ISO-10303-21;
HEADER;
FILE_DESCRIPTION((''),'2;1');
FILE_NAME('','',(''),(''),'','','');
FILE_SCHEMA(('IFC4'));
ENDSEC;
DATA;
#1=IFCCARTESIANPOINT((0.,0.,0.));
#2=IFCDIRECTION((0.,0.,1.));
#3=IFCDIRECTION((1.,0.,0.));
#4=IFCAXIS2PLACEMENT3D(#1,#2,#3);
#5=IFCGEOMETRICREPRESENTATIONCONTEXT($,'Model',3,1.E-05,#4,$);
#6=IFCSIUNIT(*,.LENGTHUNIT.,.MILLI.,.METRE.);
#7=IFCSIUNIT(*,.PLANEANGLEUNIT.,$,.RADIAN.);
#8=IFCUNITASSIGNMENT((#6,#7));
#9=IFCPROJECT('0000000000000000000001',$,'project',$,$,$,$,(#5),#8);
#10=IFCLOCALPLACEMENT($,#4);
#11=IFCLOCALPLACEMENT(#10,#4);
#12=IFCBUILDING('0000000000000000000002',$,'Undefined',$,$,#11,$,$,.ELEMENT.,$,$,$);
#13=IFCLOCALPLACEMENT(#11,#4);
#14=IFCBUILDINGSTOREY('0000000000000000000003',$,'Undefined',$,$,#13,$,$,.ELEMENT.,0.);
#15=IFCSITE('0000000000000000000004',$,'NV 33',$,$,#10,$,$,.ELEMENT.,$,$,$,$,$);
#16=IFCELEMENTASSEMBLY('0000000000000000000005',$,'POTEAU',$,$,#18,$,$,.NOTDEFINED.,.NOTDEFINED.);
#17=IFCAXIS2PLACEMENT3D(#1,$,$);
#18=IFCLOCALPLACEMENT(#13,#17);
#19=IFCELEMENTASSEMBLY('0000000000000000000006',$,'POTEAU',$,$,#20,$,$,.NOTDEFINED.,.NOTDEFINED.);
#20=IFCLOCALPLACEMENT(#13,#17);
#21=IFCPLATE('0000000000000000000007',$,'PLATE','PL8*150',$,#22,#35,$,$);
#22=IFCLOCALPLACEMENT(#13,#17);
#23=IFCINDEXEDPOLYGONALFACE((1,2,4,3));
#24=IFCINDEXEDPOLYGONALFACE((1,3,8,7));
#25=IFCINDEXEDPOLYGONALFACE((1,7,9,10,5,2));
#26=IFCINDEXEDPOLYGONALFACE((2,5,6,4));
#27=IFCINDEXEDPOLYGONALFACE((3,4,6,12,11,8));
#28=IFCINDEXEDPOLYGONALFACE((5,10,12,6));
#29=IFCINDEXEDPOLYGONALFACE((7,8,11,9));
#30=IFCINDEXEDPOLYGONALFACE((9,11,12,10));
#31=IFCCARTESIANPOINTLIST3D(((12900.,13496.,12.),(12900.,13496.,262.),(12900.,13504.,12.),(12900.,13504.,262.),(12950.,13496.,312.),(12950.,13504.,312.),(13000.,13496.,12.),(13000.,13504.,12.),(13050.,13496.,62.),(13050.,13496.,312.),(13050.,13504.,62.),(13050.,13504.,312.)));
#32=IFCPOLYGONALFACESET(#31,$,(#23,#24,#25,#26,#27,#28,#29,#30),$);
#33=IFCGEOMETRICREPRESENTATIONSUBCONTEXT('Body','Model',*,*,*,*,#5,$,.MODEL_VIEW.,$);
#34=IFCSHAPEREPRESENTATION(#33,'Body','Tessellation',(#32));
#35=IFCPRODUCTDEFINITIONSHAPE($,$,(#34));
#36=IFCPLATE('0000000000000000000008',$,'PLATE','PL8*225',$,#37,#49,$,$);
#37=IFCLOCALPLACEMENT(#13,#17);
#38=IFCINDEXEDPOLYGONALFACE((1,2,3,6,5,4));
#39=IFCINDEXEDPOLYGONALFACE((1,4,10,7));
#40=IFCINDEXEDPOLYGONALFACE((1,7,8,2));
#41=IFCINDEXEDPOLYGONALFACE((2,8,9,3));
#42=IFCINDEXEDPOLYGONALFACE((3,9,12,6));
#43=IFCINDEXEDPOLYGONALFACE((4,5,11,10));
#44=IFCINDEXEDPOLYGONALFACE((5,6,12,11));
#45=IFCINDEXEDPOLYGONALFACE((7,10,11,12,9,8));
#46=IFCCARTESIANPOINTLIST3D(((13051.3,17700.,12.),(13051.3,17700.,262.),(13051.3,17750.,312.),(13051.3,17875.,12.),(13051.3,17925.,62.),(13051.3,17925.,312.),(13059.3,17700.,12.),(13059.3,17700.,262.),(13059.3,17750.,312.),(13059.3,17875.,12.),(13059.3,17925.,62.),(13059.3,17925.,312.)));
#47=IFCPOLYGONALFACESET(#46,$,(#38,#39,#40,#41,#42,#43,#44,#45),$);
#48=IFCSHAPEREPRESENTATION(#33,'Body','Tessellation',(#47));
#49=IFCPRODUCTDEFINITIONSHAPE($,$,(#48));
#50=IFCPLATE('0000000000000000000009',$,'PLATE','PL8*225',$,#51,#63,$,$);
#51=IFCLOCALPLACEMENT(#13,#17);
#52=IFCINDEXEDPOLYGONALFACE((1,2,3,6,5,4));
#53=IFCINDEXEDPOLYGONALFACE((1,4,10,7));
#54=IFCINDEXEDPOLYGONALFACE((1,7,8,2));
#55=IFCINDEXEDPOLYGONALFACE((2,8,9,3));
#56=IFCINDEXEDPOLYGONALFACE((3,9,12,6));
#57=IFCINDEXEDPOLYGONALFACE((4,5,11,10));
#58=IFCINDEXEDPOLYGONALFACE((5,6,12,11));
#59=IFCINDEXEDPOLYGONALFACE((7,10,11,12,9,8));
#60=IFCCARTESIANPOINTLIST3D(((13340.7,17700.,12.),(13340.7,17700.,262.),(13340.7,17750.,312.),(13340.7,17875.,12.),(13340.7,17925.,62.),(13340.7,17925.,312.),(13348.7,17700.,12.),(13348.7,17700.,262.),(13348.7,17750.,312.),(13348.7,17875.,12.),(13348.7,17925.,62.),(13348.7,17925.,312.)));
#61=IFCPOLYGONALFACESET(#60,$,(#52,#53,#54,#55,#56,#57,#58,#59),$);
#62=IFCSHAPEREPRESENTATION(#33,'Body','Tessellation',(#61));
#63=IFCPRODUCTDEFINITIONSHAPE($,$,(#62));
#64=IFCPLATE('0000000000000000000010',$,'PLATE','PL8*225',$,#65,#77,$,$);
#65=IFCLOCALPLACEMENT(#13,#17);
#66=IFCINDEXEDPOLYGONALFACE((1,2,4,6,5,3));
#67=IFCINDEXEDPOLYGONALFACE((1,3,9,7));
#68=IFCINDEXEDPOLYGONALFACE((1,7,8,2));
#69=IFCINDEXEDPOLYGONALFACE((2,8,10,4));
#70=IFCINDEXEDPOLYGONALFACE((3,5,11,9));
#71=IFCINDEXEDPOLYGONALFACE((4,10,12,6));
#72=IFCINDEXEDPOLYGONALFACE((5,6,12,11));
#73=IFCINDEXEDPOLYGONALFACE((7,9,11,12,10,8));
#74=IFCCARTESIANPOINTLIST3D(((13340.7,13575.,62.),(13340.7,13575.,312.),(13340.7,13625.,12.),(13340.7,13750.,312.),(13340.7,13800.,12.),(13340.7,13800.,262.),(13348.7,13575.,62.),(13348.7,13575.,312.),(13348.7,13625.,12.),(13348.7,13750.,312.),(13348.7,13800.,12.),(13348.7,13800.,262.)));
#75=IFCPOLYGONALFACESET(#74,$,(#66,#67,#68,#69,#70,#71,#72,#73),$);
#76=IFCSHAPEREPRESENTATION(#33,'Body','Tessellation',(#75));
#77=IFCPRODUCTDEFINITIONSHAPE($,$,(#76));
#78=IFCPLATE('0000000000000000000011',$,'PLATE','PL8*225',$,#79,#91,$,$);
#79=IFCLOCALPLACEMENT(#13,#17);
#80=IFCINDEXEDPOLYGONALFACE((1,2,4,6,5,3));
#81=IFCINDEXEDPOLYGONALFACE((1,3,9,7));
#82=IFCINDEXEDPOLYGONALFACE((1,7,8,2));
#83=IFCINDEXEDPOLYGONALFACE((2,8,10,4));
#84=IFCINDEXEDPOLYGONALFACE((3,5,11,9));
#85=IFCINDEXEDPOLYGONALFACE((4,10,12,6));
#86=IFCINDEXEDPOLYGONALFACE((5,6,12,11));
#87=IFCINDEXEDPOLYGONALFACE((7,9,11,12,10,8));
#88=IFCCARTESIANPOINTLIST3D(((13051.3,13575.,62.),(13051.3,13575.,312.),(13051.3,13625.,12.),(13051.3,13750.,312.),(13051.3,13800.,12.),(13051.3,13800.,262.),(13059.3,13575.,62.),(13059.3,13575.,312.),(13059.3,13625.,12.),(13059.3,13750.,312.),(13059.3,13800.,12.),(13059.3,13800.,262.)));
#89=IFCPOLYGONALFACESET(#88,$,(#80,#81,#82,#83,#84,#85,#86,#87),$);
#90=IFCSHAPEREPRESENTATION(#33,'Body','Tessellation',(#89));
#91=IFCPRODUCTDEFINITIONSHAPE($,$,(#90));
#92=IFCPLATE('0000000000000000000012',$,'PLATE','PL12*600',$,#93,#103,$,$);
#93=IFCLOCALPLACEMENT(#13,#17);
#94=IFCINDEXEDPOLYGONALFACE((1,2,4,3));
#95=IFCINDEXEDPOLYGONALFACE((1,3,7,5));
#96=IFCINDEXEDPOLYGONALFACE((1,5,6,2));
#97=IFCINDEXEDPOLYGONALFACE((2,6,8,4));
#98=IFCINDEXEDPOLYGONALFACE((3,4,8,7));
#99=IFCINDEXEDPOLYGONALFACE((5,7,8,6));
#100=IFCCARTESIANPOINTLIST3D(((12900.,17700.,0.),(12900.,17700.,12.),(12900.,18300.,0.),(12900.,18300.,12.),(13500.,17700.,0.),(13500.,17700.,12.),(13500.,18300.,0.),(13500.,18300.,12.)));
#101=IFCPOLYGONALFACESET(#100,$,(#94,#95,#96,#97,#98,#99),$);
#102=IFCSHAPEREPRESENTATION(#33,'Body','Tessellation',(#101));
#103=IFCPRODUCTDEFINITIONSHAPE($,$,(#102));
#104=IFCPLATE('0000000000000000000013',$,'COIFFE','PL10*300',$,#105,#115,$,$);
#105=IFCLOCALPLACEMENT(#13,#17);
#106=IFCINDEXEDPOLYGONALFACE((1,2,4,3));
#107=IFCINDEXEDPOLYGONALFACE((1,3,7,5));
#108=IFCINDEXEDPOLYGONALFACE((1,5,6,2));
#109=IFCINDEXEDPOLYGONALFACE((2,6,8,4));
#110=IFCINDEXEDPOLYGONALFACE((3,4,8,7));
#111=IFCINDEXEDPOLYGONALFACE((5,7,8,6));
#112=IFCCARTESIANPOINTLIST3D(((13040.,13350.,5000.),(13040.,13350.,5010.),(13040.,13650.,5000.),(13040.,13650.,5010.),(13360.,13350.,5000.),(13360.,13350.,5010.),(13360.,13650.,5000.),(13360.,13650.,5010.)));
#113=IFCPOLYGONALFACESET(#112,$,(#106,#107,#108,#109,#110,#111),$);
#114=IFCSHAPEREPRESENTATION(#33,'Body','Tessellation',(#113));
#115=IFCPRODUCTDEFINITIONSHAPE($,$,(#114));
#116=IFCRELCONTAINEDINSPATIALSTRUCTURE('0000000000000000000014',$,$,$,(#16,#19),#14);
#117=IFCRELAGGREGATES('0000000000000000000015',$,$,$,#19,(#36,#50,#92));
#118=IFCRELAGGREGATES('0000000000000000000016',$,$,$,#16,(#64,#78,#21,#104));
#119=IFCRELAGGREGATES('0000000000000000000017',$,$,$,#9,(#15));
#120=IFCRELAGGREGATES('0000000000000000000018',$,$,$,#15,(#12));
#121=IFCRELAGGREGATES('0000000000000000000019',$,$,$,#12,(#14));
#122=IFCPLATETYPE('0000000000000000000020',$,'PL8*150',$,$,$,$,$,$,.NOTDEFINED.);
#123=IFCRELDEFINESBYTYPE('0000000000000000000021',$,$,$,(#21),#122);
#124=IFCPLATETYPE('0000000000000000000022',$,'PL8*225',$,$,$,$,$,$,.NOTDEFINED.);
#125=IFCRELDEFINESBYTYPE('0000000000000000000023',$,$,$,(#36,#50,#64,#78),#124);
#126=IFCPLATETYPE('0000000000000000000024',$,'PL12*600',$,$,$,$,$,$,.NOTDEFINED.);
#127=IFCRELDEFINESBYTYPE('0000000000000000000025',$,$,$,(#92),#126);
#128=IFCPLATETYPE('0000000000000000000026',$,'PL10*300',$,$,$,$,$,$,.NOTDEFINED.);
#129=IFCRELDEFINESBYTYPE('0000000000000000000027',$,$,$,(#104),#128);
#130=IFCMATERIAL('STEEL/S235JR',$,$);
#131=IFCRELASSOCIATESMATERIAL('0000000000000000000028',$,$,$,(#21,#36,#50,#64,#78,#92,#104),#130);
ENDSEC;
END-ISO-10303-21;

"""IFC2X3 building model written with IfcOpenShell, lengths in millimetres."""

from ifc_helpers import new_model, si_unit, frame, origin_with_axes, place, context, subcontext, project, spatial, polyline, outline, extrude, material, type_object, element, aggregate, save


model = new_model("IFC2X3")

# Units and contexts
model_context = context("Model", 3, precision=1e-05, world=origin_with_axes())
body_context = subcontext(model_context, "Body", "Model", "MODEL_VIEW")
ifc_project = project(units=[si_unit("LENGTHUNIT", "METRE", prefix="MILLI"), si_unit("PLANEANGLEUNIT", "RADIAN")], contexts=[model_context])

# Site, building, storey
site_placement = place(None, origin_with_axes())
site = spatial("IfcSite", under=ifc_project, at=site_placement, Name="NV 33", CompositionType="ELEMENT")
building_placement = place(site_placement, origin_with_axes())
building = spatial("IfcBuilding", under=site, at=building_placement, Name="Undefined", CompositionType="ELEMENT")
storey_placement = place(building_placement, origin_with_axes())
storey = spatial("IfcBuildingStorey", under=building, at=storey_placement, Name="Undefined", CompositionType="ELEMENT", Elevation=0.0)

# Element assembly
assembly_1_placement = place(storey_placement, origin_with_axes())
assembly_1 = element("IfcElementAssembly", 1, at=assembly_1_placement, inside=storey, Name="POTEAU", AssemblyPlace="NOTDEFINED", PredefinedType="NOTDEFINED")
ifc_material_1 = material(Name="STEEL/S235JR")

# Element assembly
assembly_2_placement = place(storey_placement, origin_with_axes())
assembly_2 = element("IfcElementAssembly", 2, at=assembly_2_placement, inside=storey, Name="POTEAU", AssemblyPlace="NOTDEFINED", PredefinedType="NOTDEFINED")
plate_type_1 = type_object("IfcPlateType", Name="PL8*150", PredefinedType="NOTDEFINED")

# Plates
plate_1_placement = place(assembly_1_placement, frame((13050.0, 13500.0, 12.0), z_axis=(0.0, 1.0, 0.0), x_axis=(-1.0, 0.0, 0.0)))
plate_1 = element("IfcPlate", 3, at=plate_1_placement, type_object=plate_type_1, material=ifc_material_1, Name="PLATE", Description="PL8*150", context=body_context, shape_type="SweptSolid", body=[
    extrude(outline(polyline([(0.0, 50.0), (50.0, 0.0), (150.0, 0.0), (150.0, 250.0), (100.0, 300.0), (0.0, 300.0), (0.0, 50.0)])), frame((0.0, 0.0, -4.0), z_axis=(0.0, 0.0, 1.0), x_axis=(1.0, 0.0, 0.0)), (0.0, 0.0, 1.0), 8.0),
])
plate_type_2 = type_object("IfcPlateType", Name="PL8*225", PredefinedType="NOTDEFINED")
plate_2_placement = place(assembly_2_placement, frame((13055.3, 17925.0, 12.0), z_axis=(-1.0, 0.0, 0.0), x_axis=(0.0, -1.0, 0.0)))
plate_2 = element("IfcPlate", 4, at=plate_2_placement, type_object=plate_type_2, material=ifc_material_1, Name="PLATE", Description="PL8*225", context=body_context, shape_type="SweptSolid", body=[
    extrude(outline(polyline([(0.0, 50.0), (50.0, 0.0), (225.0, 0.0), (225.0, 250.0), (175.0, 300.0), (0.0, 300.0), (0.0, 50.0)])), frame((0.0, 0.0, -4.0), z_axis=(0.0, 0.0, 1.0), x_axis=(1.0, 0.0, 0.0)), (0.0, 0.0, 1.0), 8.0),
])
plate_3_placement = place(assembly_2_placement, frame((13344.7, 17925.0, 12.0), z_axis=(-1.0, 0.0, 0.0), x_axis=(0.0, -1.0, 0.0)))
plate_3 = element("IfcPlate", 5, at=plate_3_placement, type_object=plate_type_2, material=ifc_material_1, Name="PLATE", Description="PL8*225", context=body_context, shape_type="SweptSolid", body=[
    extrude(outline(polyline([(0.0, 50.0), (50.0, 0.0), (225.0, 0.0), (225.0, 250.0), (175.0, 300.0), (0.0, 300.0), (0.0, 50.0)])), frame((0.0, 0.0, -4.0), z_axis=(0.0, 0.0, 1.0), x_axis=(1.0, 0.0, 0.0)), (0.0, 0.0, 1.0), 8.0),
])
plate_4_placement = place(assembly_1_placement, frame((13344.7, 13575.0, 12.0), z_axis=(1.0, 0.0, 0.0), x_axis=(0.0, 1.0, 0.0)))
plate_4 = element("IfcPlate", 6, at=plate_4_placement, type_object=plate_type_2, material=ifc_material_1, Name="PLATE", Description="PL8*225", context=body_context, shape_type="SweptSolid", body=[
    extrude(outline(polyline([(0.0, 50.0), (50.0, 0.0), (225.0, 0.0), (225.0, 250.0), (175.0, 300.0), (0.0, 300.0), (0.0, 50.0)])), frame((0.0, 0.0, -4.0), z_axis=(0.0, 0.0, 1.0), x_axis=(1.0, 0.0, 0.0)), (0.0, 0.0, 1.0), 8.0),
])
plate_5_placement = place(assembly_1_placement, frame((13055.3, 13575.0, 12.0), z_axis=(1.0, 0.0, 0.0), x_axis=(0.0, 1.0, 0.0)))
plate_5 = element("IfcPlate", 7, at=plate_5_placement, type_object=plate_type_2, material=ifc_material_1, Name="PLATE", Description="PL8*225", context=body_context, shape_type="SweptSolid", body=[
    extrude(outline(polyline([(0.0, 50.0), (50.0, 0.0), (225.0, 0.0), (225.0, 250.0), (175.0, 300.0), (0.0, 300.0), (0.0, 50.0)])), frame((0.0, 0.0, -4.0), z_axis=(0.0, 0.0, 1.0), x_axis=(1.0, 0.0, 0.0)), (0.0, 0.0, 1.0), 8.0),
])
plate_type_3 = type_object("IfcPlateType", Name="PL12*600", PredefinedType="NOTDEFINED")
plate_6_placement = place(assembly_2_placement, frame((12900.0, 17700.0, 6.0), z_axis=(0.0, 0.0, 1.0), x_axis=(1.0, 0.0, 0.0)))
plate_6 = element("IfcPlate", 8, at=plate_6_placement, type_object=plate_type_3, material=ifc_material_1, Name="PLATE", Description="PL12*600", context=body_context, shape_type="SweptSolid", body=[
    extrude(outline(polyline([(0.0, 0.0), (600.0, 0.0), (600.0, 600.0), (0.0, 600.0), (0.0, 0.0)])), frame((0.0, 0.0, -6.0), z_axis=(0.0, 0.0, 1.0), x_axis=(1.0, 0.0, 0.0)), (0.0, 0.0, 1.0), 12.0),
])
aggregate(assembly_2, [plate_2, plate_3, plate_6])
plate_type_4 = type_object("IfcPlateType", Name="PL10*300", PredefinedType="NOTDEFINED")
plate_7_placement = place(assembly_1_placement, frame((13040.0, 13650.0, 5005.0), z_axis=(0.0, 0.0, 1.0), x_axis=(0.0, -1.0, 0.0)))
plate_7 = element("IfcPlate", 9, at=plate_7_placement, type_object=plate_type_4, material=ifc_material_1, Name="COIFFE", Description="PL10*300", context=body_context, shape_type="SweptSolid", body=[
    extrude(outline(polyline([(0.0, 0.0), (300.0, 0.0), (300.0, 320.0), (0.0, 320.0), (0.0, 0.0)])), frame((0.0, 0.0, -5.0), z_axis=(0.0, 0.0, 1.0), x_axis=(1.0, 0.0, 0.0)), (0.0, 0.0, 1.0), 10.0),
])

aggregate(assembly_1, [plate_4, plate_5, plate_1, plate_7])

save(model, "model.ifc")
